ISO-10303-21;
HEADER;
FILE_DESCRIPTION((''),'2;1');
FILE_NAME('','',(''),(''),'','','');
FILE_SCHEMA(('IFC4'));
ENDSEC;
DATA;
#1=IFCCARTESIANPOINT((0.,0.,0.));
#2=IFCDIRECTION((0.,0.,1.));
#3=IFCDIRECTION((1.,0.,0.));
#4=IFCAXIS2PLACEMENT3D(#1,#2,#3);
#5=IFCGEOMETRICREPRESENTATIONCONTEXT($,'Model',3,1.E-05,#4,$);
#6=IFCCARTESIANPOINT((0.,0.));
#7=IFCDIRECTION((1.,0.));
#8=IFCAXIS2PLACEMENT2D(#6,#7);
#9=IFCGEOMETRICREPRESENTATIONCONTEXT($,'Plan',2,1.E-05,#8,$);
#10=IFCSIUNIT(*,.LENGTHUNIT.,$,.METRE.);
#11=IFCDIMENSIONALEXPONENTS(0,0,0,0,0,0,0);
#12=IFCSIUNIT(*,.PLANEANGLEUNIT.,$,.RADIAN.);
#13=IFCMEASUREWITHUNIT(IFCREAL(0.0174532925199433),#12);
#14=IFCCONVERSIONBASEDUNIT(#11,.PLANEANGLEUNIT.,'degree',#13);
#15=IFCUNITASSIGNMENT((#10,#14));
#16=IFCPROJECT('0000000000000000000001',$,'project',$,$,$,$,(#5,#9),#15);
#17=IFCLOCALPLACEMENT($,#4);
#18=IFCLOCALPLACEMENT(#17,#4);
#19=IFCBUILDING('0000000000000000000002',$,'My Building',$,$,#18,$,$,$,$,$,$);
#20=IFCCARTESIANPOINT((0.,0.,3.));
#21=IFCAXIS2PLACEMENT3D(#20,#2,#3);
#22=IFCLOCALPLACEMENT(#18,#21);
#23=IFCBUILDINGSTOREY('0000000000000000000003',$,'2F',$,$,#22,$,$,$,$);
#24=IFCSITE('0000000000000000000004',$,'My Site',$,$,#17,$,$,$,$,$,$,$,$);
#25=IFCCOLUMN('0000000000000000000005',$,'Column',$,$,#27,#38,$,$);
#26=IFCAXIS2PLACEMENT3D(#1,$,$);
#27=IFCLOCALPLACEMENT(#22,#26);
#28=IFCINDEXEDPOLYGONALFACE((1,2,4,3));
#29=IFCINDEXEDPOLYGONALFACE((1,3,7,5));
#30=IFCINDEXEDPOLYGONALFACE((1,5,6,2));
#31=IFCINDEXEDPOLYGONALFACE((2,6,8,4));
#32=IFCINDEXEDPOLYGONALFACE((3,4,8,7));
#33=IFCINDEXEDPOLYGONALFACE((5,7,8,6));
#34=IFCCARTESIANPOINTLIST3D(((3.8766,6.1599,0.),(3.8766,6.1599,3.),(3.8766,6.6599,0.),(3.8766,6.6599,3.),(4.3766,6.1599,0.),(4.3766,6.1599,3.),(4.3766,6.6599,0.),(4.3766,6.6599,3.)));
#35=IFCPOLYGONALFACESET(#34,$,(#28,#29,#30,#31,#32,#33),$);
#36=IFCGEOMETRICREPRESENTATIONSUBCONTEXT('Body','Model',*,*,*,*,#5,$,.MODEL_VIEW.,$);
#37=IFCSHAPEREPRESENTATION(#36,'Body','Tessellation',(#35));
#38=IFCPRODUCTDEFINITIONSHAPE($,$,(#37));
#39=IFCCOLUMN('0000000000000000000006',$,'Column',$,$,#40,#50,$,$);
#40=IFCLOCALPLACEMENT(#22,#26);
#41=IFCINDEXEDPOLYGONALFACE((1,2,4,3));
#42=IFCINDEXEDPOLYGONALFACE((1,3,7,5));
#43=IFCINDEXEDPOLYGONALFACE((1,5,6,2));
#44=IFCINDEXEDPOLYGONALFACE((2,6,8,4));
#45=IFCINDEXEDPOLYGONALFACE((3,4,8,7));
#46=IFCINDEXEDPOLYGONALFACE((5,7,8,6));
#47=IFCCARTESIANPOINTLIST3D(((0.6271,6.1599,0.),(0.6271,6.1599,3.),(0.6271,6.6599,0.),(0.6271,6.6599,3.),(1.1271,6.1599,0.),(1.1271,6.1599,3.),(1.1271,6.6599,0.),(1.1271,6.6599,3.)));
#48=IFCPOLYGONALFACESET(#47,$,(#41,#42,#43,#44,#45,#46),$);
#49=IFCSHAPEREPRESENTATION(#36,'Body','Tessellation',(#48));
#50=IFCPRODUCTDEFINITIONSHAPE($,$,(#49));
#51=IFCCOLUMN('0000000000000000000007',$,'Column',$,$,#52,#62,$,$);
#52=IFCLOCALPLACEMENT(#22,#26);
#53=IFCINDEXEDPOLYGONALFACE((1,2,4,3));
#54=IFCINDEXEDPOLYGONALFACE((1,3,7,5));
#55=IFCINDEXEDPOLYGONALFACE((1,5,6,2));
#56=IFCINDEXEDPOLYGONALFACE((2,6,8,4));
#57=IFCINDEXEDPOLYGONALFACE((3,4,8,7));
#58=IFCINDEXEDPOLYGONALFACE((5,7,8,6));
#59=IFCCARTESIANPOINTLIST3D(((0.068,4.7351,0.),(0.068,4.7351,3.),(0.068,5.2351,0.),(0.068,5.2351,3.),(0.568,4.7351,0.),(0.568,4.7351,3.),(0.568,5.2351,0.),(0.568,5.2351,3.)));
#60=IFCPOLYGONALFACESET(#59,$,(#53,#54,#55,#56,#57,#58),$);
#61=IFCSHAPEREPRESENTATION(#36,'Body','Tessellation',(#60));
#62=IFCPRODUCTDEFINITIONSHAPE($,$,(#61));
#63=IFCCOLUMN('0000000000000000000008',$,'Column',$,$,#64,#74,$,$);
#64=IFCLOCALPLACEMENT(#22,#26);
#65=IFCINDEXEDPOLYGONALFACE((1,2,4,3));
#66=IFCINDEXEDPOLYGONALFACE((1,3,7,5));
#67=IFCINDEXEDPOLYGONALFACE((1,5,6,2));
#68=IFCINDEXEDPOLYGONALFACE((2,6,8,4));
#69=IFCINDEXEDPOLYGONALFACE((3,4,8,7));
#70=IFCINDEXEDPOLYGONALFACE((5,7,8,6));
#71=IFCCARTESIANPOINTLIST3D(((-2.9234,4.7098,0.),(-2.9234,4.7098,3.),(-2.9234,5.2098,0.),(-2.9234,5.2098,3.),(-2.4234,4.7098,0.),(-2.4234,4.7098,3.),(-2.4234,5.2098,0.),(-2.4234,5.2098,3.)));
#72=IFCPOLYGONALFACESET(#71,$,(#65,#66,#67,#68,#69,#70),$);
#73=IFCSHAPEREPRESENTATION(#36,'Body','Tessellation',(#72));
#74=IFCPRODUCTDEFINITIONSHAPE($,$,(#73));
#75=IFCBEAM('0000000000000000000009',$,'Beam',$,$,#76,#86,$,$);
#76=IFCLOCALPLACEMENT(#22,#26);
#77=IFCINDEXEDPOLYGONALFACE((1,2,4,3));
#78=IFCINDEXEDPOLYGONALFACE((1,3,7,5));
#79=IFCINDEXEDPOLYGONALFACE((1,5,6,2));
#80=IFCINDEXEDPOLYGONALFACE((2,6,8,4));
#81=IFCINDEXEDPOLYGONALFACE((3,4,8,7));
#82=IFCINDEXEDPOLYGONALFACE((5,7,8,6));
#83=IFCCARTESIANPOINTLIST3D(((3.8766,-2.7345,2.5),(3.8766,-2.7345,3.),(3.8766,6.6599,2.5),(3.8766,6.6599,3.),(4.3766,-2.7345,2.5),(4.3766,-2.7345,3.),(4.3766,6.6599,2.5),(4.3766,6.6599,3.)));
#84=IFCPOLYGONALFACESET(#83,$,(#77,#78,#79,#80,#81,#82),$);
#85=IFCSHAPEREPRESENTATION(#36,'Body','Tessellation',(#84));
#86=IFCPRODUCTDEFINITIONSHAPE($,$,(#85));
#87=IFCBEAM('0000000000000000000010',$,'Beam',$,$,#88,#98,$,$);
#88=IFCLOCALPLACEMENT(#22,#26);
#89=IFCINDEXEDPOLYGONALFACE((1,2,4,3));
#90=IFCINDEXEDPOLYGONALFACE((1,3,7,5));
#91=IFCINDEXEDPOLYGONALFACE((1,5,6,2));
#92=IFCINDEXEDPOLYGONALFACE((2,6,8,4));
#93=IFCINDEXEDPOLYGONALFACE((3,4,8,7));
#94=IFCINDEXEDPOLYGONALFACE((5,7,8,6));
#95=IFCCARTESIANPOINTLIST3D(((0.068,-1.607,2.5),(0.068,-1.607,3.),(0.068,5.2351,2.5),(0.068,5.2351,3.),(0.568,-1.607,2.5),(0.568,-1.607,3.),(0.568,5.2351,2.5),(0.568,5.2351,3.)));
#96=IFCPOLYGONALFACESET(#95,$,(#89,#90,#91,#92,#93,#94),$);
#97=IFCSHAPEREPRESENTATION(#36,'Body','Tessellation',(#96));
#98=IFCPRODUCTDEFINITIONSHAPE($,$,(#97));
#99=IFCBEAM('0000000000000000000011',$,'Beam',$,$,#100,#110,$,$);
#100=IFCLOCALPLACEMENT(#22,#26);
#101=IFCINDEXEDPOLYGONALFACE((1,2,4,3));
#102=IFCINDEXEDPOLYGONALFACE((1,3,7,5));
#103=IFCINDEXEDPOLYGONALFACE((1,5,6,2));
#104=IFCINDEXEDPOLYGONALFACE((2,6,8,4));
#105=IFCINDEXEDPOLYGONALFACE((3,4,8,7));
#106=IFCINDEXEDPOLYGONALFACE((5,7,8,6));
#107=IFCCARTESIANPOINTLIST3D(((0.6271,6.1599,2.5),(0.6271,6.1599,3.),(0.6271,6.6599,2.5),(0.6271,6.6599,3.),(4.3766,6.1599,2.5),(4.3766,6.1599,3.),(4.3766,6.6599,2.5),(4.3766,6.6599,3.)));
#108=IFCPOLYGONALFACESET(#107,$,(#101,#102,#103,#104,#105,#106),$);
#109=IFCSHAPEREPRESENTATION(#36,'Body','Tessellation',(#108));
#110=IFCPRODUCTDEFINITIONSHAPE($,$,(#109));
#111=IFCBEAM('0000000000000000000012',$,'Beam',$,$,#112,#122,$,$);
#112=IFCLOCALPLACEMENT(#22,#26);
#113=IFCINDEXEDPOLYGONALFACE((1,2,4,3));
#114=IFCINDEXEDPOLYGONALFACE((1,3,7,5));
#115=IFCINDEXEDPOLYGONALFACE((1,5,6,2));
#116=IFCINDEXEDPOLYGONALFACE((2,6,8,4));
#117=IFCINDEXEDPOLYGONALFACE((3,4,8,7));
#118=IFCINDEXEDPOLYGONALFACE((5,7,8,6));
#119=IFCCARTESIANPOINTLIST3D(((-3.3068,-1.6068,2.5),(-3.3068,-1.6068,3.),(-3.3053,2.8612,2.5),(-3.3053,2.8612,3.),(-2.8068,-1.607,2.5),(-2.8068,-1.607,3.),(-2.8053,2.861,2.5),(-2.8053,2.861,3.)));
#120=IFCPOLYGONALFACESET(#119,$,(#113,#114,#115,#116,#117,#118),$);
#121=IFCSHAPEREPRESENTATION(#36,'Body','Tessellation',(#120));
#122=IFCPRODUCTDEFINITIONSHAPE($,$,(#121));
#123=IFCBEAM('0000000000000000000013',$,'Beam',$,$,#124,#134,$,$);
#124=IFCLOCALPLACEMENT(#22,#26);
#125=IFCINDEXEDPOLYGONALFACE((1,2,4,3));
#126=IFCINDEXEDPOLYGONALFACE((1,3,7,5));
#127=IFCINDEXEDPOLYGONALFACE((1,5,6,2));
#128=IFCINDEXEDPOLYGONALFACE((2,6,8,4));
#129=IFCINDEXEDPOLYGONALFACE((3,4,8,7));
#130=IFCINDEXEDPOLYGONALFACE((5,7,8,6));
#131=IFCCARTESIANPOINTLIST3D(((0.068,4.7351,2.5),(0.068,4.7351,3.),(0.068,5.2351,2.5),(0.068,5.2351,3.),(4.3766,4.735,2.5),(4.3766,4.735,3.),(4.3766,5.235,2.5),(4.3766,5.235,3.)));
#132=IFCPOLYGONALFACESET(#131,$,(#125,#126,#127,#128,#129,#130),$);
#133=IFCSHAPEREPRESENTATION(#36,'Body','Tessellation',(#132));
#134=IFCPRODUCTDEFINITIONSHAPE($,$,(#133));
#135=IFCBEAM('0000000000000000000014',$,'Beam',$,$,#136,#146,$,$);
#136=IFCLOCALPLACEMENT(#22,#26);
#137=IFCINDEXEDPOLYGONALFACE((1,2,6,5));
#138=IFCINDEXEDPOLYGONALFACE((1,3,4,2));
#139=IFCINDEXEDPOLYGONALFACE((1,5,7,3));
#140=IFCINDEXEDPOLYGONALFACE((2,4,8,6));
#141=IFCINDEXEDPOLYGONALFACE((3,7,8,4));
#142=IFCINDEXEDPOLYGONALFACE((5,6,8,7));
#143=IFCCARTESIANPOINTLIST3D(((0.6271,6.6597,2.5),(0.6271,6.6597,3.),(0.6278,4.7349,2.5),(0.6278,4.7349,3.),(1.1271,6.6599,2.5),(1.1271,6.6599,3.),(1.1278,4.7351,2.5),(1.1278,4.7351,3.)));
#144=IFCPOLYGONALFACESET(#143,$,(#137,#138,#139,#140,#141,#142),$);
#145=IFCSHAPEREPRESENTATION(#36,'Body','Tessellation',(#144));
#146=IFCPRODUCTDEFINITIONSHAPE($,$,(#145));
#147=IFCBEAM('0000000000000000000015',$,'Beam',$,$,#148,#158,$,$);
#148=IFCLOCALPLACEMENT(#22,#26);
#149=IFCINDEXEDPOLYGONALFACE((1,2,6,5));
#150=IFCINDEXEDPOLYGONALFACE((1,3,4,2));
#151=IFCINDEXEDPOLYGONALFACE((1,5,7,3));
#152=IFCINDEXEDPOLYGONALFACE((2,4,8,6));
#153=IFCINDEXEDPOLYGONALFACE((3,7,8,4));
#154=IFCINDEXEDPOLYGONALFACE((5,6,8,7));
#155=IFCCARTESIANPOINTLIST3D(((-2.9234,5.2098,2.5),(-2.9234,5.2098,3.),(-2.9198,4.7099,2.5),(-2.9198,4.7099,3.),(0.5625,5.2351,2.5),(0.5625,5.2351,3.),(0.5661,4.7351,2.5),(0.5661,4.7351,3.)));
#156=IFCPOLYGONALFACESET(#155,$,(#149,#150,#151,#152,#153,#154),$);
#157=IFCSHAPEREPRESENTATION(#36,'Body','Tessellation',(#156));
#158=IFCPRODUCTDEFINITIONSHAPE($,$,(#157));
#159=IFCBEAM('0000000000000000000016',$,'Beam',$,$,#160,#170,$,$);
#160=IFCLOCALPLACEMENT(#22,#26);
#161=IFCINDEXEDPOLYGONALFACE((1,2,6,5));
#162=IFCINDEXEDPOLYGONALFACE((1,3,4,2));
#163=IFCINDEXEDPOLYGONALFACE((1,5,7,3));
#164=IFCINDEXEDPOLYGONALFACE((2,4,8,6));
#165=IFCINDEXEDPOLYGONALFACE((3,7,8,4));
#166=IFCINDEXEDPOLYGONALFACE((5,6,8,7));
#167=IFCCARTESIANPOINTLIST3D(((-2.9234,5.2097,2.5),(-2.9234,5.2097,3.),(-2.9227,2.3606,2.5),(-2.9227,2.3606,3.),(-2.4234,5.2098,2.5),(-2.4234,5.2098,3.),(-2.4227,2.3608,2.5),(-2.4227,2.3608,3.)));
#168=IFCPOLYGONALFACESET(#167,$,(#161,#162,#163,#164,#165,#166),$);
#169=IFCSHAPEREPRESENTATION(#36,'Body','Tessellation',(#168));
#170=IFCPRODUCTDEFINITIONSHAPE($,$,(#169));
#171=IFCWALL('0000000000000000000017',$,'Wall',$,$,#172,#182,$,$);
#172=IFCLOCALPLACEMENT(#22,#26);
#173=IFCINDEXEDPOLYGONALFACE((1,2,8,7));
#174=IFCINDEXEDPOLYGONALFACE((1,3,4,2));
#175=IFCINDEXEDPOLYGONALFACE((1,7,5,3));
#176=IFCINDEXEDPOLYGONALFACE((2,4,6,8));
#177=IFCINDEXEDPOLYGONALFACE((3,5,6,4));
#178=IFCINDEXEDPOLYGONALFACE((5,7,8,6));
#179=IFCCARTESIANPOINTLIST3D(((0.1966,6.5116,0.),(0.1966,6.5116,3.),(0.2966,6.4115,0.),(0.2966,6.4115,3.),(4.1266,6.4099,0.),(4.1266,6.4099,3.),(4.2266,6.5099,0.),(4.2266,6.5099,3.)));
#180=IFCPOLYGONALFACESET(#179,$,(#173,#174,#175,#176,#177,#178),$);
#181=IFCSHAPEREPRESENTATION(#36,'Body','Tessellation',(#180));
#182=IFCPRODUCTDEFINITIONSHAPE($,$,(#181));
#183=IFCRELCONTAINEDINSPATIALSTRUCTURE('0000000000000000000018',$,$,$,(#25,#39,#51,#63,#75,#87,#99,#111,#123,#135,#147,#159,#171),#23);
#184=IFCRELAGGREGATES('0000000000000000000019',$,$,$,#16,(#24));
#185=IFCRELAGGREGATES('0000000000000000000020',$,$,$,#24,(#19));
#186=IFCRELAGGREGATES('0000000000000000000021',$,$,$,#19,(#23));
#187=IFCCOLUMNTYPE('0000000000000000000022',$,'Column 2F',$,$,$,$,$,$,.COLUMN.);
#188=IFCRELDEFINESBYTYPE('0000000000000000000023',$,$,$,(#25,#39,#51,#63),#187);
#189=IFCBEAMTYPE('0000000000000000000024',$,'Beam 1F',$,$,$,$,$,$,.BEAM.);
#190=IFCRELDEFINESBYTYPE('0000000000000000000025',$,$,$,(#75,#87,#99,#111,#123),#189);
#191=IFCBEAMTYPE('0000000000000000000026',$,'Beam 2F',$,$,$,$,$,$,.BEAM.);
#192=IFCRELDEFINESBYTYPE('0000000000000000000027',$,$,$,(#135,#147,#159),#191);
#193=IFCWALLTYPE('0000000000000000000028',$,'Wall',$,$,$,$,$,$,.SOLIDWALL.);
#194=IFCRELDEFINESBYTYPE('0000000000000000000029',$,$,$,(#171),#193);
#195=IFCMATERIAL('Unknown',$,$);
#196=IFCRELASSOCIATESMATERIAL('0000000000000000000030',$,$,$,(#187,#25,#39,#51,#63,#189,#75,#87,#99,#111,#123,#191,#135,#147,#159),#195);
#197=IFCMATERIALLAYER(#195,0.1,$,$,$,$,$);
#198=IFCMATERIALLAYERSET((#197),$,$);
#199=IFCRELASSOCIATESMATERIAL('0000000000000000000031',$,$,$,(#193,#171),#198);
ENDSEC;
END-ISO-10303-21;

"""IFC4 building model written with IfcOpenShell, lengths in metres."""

from ifc_helpers import new_model, entity, si_unit, converted_unit, frame, origin_with_axes, origin_2d_with_axis, place, context, subcontext, project, spatial, line, indexed_curve, rectangle, outline, extrude, material, layer, layer_set, layer_usage, material_profile, profile_set, profile_usage, type_object, element, save


model = new_model("IFC4")

# Units and contexts
model_context = context("Model", 3, precision=1e-05, world=origin_with_axes())
plan_context = context("Plan", 2, precision=1e-05, world=origin_2d_with_axis())
body_context_1 = subcontext(model_context, "Body", "Model", "MODEL_VIEW")
ifc_project = project(units=[si_unit("LENGTHUNIT", "METRE"), converted_unit("PLANEANGLEUNIT", "degree", entity("IfcReal", 0.0174532925199433), si_unit("PLANEANGLEUNIT", "RADIAN"), dimensions=[0, 0, 0, 0, 0, 0, 0])], contexts=[model_context, plan_context])

# Site, building, storey
site_placement = place(None, origin_with_axes())
site = spatial("IfcSite", under=ifc_project, at=site_placement, Name="My Site")
building_placement = place(site_placement, origin_with_axes())
building = spatial("IfcBuilding", under=site, at=building_placement, Name="My Building")
storey_placement = place(building_placement, frame((0.0, 0.0, 3.0), z_axis=(0.0, 0.0, 1.0), x_axis=(1.0, 0.0, 0.0)))
storey = spatial("IfcBuildingStorey", under=building, at=storey_placement, Name="2F")

# Columns
ifc_material = material(Name="Unknown")
ifc_material_profile_1 = material_profile(ifc_material, rectangle(XDim=0.5, YDim=0.5))
ifc_profile_set_1 = profile_set([ifc_material_profile_1])
ifc_profile_usage_1 = profile_usage(ifc_profile_set_1, cardinal=1)
column_type = type_object("IfcColumnType", Name="Column 2F", PredefinedType="COLUMN", material=ifc_profile_set_1)
column_1_placement = place(storey_placement, frame((4.3766, 6.1599, 0.0), z_axis=(0.0, 0.0, 1.0), x_axis=(1.0, 0.0, 0.0)))
element("IfcColumn", 1, at=column_1_placement, inside=storey, type_object=column_type, material=ifc_profile_usage_1, Name="Column", context=body_context_1, shape_type="SweptSolid", body=[
    extrude(rectangle(XDim=0.5, YDim=0.5), frame((-0.25, 0.25, 0.0), z_axis=(0.0, 0.0, 1.0), x_axis=(1.0, 0.0, 0.0)), (0.0, 0.0, 1.0), 3.0),
])
ifc_profile_usage_2 = profile_usage(ifc_profile_set_1, cardinal=1)
column_2_placement = place(storey_placement, frame((1.1271, 6.1599, 0.0), z_axis=(0.0, 0.0, 1.0), x_axis=(1.0, 0.0, 0.0)))
element("IfcColumn", 2, at=column_2_placement, inside=storey, type_object=column_type, material=ifc_profile_usage_2, Name="Column", context=body_context_1, shape_type="SweptSolid", body=[
    extrude(rectangle(XDim=0.5, YDim=0.5), frame((-0.25, 0.25, 0.0), z_axis=(0.0, 0.0, 1.0), x_axis=(1.0, 0.0, 0.0)), (0.0, 0.0, 1.0), 3.0),
])
ifc_profile_usage_3 = profile_usage(ifc_profile_set_1, cardinal=3)
column_3_placement = place(storey_placement, frame((0.068, 4.7351, 0.0), z_axis=(0.0, 0.0, 1.0), x_axis=(1.0, 0.0, 0.0)))
element("IfcColumn", 3, at=column_3_placement, inside=storey, type_object=column_type, material=ifc_profile_usage_3, Name="Column", context=body_context_1, shape_type="SweptSolid", body=[
    extrude(rectangle(XDim=0.5, YDim=0.5), frame((0.25, 0.25, 0.0), z_axis=(0.0, 0.0, 1.0), x_axis=(1.0, 0.0, 0.0)), (0.0, 0.0, 1.0), 3.0),
])
ifc_profile_usage_4 = profile_usage(ifc_profile_set_1, cardinal=7)
column_4_placement = place(storey_placement, frame((-2.4234, 5.2098, 0.0), z_axis=(0.0, 0.0, 1.0), x_axis=(1.0, 0.0, 0.0)))
element("IfcColumn", 4, at=column_4_placement, inside=storey, type_object=column_type, material=ifc_profile_usage_4, Name="Column", context=body_context_1, shape_type="SweptSolid", body=[
    extrude(rectangle(XDim=0.5, YDim=0.5), frame((-0.25, -0.25, 0.0), z_axis=(0.0, 0.0, 1.0), x_axis=(1.0, 0.0, 0.0)), (0.0, 0.0, 1.0), 3.0),
])

# Beams
ifc_material_profile_2 = material_profile(ifc_material, rectangle(XDim=0.5, YDim=0.5))
ifc_profile_set_2 = profile_set([ifc_material_profile_2])
ifc_profile_usage_5 = profile_usage(ifc_profile_set_2, cardinal=7)
beam_type_1 = type_object("IfcBeamType", Name="Beam 1F", PredefinedType="BEAM", material=ifc_profile_set_2)
beam_1_placement = place(storey_placement, frame((4.3766, 6.6599, 3.0), z_axis=(0.0, -1.0, 0.0), x_axis=(1.0, 0.0, 0.0)))
element("IfcBeam", 5, at=beam_1_placement, inside=storey, type_object=beam_type_1, material=ifc_profile_usage_5, Name="Beam", context=body_context_1, shape_type="SweptSolid", body=[
    extrude(rectangle(XDim=0.5, YDim=0.5), frame((-0.25, -0.25, 0.0), z_axis=(0.0, 0.0, 1.0), x_axis=(1.0, 0.0, 0.0)), (0.0, 0.0, 1.0), 9.3944),
])
ifc_profile_usage_6 = profile_usage(ifc_profile_set_2, cardinal=7)
beam_2_placement = place(storey_placement, frame((0.568, 5.2351, 3.0), z_axis=(0.0, -1.0, 0.0), x_axis=(1.0, 0.0, 0.0)))
element("IfcBeam", 6, at=beam_2_placement, inside=storey, type_object=beam_type_1, material=ifc_profile_usage_6, Name="Beam", context=body_context_1, shape_type="SweptSolid", body=[
    extrude(rectangle(XDim=0.5, YDim=0.5), frame((-0.25, -0.25, 0.0), z_axis=(0.0, 0.0, 1.0), x_axis=(1.0, 0.0, 0.0)), (0.0, 0.0, 1.0), 6.8421),
])
ifc_profile_usage_7 = profile_usage(ifc_profile_set_2, cardinal=7)
beam_3_placement = place(storey_placement, frame((0.6271, 6.6599, 3.0), z_axis=(1.0, 0.0, 0.0), x_axis=(0.0, 1.0, 0.0)))
element("IfcBeam", 7, at=beam_3_placement, inside=storey, type_object=beam_type_1, material=ifc_profile_usage_7, Name="Beam", context=body_context_1, shape_type="SweptSolid", body=[
    extrude(rectangle(XDim=0.5, YDim=0.5), frame((-0.25, -0.25, 0.0), z_axis=(0.0, 0.0, 1.0), x_axis=(1.0, 0.0, 0.0)), (0.0, 0.0, 1.0), 3.7495),
])
ifc_profile_usage_8 = profile_usage(ifc_profile_set_2, cardinal=7)
beam_4_placement = place(storey_placement, frame((-2.8053, 2.861, 3.0), z_axis=(-0.000336, -1.0, 0.0), x_axis=(1.0, -0.000336, 0.0)))
element("IfcBeam", 8, at=beam_4_placement, inside=storey, type_object=beam_type_1, material=ifc_profile_usage_8, Name="Beam", context=body_context_1, shape_type="SweptSolid", body=[
    extrude(rectangle(XDim=0.5, YDim=0.5), frame((-0.25, -0.25, 0.0), z_axis=(0.0, 0.0, 1.0), x_axis=(1.0, 0.0, 0.0)), (0.0, 0.0, 1.0), 4.468),
])
ifc_profile_usage_9 = profile_usage(ifc_profile_set_2, cardinal=7)
beam_5_placement = place(storey_placement, frame((0.068, 5.2351, 3.0), z_axis=(1.0, -0.000031, 0.0), x_axis=(0.000031, 1.0, 0.0)))
element("IfcBeam", 9, at=beam_5_placement, inside=storey, type_object=beam_type_1, material=ifc_profile_usage_9, Name="Beam", context=body_context_1, shape_type="SweptSolid", body=[
    extrude(rectangle(XDim=0.5, YDim=0.5), frame((-0.25, -0.25, 0.0), z_axis=(0.0, 0.0, 1.0), x_axis=(1.0, 0.0, 0.0)), (0.0, 0.0, 1.0), 4.3086),
])
ifc_material_profile_3 = material_profile(ifc_material, rectangle(XDim=0.5, YDim=0.5))
ifc_profile_set_3 = profile_set([ifc_material_profile_3])
ifc_profile_usage_10 = profile_usage(ifc_profile_set_3, cardinal=7)
beam_type_2 = type_object("IfcBeamType", Name="Beam 2F", PredefinedType="BEAM", material=ifc_profile_set_3)
beam_6_placement = place(storey_placement, frame((1.1271, 6.6599, 3.0), z_axis=(0.000332, -1.0, 0.0), x_axis=(1.0, 0.000332, 0.0)))
element("IfcBeam", 10, at=beam_6_placement, inside=storey, type_object=beam_type_2, material=ifc_profile_usage_10, Name="Beam", context=body_context_1, shape_type="SweptSolid", body=[
    extrude(rectangle(XDim=0.5, YDim=0.5), frame((-0.25, -0.25, 0.0), z_axis=(0.0, 0.0, 1.0), x_axis=(1.0, 0.0, 0.0)), (0.0, 0.0, 1.0), 1.9248),
])
ifc_profile_usage_11 = profile_usage(ifc_profile_set_3, cardinal=7)
beam_7_placement = place(storey_placement, frame((-2.9234, 5.2098, 3.0), z_axis=(0.999974, 0.007246, 0.0), x_axis=(-0.007246, 0.999974, 0.0)))
element("IfcBeam", 11, at=beam_7_placement, inside=storey, type_object=beam_type_2, material=ifc_profile_usage_11, Name="Beam", context=body_context_1, shape_type="SweptSolid", body=[
    extrude(rectangle(XDim=0.5, YDim=0.5), frame((-0.25, -0.25, 0.0), z_axis=(0.0, 0.0, 1.0), x_axis=(1.0, 0.0, 0.0)), (0.0, 0.0, 1.0), 3.486),
])
ifc_profile_usage_12 = profile_usage(ifc_profile_set_3, cardinal=7)
beam_8_placement = place(storey_placement, frame((-2.4234, 5.2098, 3.0), z_axis=(0.000239, -1.0, 0.0), x_axis=(1.0, 0.000239, 0.0)))
element("IfcBeam", 12, at=beam_8_placement, inside=storey, type_object=beam_type_2, material=ifc_profile_usage_12, Name="Beam", context=body_context_1, shape_type="SweptSolid", body=[
    extrude(rectangle(XDim=0.5, YDim=0.5), frame((-0.25, -0.25, 0.0), z_axis=(0.0, 0.0, 1.0), x_axis=(1.0, 0.0, 0.0)), (0.0, 0.0, 1.0), 2.8491),
])

# Wall
ifc_layer = layer(ifc_material, 0.1)
ifc_layer_set = layer_set([ifc_layer])
ifc_layer_usage_1 = layer_usage(ifc_layer_set, "AXIS2", "POSITIVE", 0.0)
wall_type = type_object("IfcWallType", Name="Wall", PredefinedType="SOLIDWALL", material=ifc_layer_set)
wall_1_placement = place(storey_placement, frame((4.2266, 6.5099, 0.0), z_axis=(0.0, 0.0, 1.0), x_axis=(-1.0, 0.000415, 0.0)))
element("IfcWall", 13, at=wall_1_placement, inside=storey, type_object=wall_type, material=ifc_layer_usage_1, Name="Wall", context=body_context_1, shape_type="SweptSolid", body=[
    extrude(outline(indexed_curve([(0.0, 0.0), (0.1, 0.1), (3.93, 0.1), (4.03, 0.0)], segments=[line(1, 2, 3, 4, 1)])), origin_with_axes(), (0.0, 0.0, 1.0), 3.0),
])

save(model, "model.ifc")
